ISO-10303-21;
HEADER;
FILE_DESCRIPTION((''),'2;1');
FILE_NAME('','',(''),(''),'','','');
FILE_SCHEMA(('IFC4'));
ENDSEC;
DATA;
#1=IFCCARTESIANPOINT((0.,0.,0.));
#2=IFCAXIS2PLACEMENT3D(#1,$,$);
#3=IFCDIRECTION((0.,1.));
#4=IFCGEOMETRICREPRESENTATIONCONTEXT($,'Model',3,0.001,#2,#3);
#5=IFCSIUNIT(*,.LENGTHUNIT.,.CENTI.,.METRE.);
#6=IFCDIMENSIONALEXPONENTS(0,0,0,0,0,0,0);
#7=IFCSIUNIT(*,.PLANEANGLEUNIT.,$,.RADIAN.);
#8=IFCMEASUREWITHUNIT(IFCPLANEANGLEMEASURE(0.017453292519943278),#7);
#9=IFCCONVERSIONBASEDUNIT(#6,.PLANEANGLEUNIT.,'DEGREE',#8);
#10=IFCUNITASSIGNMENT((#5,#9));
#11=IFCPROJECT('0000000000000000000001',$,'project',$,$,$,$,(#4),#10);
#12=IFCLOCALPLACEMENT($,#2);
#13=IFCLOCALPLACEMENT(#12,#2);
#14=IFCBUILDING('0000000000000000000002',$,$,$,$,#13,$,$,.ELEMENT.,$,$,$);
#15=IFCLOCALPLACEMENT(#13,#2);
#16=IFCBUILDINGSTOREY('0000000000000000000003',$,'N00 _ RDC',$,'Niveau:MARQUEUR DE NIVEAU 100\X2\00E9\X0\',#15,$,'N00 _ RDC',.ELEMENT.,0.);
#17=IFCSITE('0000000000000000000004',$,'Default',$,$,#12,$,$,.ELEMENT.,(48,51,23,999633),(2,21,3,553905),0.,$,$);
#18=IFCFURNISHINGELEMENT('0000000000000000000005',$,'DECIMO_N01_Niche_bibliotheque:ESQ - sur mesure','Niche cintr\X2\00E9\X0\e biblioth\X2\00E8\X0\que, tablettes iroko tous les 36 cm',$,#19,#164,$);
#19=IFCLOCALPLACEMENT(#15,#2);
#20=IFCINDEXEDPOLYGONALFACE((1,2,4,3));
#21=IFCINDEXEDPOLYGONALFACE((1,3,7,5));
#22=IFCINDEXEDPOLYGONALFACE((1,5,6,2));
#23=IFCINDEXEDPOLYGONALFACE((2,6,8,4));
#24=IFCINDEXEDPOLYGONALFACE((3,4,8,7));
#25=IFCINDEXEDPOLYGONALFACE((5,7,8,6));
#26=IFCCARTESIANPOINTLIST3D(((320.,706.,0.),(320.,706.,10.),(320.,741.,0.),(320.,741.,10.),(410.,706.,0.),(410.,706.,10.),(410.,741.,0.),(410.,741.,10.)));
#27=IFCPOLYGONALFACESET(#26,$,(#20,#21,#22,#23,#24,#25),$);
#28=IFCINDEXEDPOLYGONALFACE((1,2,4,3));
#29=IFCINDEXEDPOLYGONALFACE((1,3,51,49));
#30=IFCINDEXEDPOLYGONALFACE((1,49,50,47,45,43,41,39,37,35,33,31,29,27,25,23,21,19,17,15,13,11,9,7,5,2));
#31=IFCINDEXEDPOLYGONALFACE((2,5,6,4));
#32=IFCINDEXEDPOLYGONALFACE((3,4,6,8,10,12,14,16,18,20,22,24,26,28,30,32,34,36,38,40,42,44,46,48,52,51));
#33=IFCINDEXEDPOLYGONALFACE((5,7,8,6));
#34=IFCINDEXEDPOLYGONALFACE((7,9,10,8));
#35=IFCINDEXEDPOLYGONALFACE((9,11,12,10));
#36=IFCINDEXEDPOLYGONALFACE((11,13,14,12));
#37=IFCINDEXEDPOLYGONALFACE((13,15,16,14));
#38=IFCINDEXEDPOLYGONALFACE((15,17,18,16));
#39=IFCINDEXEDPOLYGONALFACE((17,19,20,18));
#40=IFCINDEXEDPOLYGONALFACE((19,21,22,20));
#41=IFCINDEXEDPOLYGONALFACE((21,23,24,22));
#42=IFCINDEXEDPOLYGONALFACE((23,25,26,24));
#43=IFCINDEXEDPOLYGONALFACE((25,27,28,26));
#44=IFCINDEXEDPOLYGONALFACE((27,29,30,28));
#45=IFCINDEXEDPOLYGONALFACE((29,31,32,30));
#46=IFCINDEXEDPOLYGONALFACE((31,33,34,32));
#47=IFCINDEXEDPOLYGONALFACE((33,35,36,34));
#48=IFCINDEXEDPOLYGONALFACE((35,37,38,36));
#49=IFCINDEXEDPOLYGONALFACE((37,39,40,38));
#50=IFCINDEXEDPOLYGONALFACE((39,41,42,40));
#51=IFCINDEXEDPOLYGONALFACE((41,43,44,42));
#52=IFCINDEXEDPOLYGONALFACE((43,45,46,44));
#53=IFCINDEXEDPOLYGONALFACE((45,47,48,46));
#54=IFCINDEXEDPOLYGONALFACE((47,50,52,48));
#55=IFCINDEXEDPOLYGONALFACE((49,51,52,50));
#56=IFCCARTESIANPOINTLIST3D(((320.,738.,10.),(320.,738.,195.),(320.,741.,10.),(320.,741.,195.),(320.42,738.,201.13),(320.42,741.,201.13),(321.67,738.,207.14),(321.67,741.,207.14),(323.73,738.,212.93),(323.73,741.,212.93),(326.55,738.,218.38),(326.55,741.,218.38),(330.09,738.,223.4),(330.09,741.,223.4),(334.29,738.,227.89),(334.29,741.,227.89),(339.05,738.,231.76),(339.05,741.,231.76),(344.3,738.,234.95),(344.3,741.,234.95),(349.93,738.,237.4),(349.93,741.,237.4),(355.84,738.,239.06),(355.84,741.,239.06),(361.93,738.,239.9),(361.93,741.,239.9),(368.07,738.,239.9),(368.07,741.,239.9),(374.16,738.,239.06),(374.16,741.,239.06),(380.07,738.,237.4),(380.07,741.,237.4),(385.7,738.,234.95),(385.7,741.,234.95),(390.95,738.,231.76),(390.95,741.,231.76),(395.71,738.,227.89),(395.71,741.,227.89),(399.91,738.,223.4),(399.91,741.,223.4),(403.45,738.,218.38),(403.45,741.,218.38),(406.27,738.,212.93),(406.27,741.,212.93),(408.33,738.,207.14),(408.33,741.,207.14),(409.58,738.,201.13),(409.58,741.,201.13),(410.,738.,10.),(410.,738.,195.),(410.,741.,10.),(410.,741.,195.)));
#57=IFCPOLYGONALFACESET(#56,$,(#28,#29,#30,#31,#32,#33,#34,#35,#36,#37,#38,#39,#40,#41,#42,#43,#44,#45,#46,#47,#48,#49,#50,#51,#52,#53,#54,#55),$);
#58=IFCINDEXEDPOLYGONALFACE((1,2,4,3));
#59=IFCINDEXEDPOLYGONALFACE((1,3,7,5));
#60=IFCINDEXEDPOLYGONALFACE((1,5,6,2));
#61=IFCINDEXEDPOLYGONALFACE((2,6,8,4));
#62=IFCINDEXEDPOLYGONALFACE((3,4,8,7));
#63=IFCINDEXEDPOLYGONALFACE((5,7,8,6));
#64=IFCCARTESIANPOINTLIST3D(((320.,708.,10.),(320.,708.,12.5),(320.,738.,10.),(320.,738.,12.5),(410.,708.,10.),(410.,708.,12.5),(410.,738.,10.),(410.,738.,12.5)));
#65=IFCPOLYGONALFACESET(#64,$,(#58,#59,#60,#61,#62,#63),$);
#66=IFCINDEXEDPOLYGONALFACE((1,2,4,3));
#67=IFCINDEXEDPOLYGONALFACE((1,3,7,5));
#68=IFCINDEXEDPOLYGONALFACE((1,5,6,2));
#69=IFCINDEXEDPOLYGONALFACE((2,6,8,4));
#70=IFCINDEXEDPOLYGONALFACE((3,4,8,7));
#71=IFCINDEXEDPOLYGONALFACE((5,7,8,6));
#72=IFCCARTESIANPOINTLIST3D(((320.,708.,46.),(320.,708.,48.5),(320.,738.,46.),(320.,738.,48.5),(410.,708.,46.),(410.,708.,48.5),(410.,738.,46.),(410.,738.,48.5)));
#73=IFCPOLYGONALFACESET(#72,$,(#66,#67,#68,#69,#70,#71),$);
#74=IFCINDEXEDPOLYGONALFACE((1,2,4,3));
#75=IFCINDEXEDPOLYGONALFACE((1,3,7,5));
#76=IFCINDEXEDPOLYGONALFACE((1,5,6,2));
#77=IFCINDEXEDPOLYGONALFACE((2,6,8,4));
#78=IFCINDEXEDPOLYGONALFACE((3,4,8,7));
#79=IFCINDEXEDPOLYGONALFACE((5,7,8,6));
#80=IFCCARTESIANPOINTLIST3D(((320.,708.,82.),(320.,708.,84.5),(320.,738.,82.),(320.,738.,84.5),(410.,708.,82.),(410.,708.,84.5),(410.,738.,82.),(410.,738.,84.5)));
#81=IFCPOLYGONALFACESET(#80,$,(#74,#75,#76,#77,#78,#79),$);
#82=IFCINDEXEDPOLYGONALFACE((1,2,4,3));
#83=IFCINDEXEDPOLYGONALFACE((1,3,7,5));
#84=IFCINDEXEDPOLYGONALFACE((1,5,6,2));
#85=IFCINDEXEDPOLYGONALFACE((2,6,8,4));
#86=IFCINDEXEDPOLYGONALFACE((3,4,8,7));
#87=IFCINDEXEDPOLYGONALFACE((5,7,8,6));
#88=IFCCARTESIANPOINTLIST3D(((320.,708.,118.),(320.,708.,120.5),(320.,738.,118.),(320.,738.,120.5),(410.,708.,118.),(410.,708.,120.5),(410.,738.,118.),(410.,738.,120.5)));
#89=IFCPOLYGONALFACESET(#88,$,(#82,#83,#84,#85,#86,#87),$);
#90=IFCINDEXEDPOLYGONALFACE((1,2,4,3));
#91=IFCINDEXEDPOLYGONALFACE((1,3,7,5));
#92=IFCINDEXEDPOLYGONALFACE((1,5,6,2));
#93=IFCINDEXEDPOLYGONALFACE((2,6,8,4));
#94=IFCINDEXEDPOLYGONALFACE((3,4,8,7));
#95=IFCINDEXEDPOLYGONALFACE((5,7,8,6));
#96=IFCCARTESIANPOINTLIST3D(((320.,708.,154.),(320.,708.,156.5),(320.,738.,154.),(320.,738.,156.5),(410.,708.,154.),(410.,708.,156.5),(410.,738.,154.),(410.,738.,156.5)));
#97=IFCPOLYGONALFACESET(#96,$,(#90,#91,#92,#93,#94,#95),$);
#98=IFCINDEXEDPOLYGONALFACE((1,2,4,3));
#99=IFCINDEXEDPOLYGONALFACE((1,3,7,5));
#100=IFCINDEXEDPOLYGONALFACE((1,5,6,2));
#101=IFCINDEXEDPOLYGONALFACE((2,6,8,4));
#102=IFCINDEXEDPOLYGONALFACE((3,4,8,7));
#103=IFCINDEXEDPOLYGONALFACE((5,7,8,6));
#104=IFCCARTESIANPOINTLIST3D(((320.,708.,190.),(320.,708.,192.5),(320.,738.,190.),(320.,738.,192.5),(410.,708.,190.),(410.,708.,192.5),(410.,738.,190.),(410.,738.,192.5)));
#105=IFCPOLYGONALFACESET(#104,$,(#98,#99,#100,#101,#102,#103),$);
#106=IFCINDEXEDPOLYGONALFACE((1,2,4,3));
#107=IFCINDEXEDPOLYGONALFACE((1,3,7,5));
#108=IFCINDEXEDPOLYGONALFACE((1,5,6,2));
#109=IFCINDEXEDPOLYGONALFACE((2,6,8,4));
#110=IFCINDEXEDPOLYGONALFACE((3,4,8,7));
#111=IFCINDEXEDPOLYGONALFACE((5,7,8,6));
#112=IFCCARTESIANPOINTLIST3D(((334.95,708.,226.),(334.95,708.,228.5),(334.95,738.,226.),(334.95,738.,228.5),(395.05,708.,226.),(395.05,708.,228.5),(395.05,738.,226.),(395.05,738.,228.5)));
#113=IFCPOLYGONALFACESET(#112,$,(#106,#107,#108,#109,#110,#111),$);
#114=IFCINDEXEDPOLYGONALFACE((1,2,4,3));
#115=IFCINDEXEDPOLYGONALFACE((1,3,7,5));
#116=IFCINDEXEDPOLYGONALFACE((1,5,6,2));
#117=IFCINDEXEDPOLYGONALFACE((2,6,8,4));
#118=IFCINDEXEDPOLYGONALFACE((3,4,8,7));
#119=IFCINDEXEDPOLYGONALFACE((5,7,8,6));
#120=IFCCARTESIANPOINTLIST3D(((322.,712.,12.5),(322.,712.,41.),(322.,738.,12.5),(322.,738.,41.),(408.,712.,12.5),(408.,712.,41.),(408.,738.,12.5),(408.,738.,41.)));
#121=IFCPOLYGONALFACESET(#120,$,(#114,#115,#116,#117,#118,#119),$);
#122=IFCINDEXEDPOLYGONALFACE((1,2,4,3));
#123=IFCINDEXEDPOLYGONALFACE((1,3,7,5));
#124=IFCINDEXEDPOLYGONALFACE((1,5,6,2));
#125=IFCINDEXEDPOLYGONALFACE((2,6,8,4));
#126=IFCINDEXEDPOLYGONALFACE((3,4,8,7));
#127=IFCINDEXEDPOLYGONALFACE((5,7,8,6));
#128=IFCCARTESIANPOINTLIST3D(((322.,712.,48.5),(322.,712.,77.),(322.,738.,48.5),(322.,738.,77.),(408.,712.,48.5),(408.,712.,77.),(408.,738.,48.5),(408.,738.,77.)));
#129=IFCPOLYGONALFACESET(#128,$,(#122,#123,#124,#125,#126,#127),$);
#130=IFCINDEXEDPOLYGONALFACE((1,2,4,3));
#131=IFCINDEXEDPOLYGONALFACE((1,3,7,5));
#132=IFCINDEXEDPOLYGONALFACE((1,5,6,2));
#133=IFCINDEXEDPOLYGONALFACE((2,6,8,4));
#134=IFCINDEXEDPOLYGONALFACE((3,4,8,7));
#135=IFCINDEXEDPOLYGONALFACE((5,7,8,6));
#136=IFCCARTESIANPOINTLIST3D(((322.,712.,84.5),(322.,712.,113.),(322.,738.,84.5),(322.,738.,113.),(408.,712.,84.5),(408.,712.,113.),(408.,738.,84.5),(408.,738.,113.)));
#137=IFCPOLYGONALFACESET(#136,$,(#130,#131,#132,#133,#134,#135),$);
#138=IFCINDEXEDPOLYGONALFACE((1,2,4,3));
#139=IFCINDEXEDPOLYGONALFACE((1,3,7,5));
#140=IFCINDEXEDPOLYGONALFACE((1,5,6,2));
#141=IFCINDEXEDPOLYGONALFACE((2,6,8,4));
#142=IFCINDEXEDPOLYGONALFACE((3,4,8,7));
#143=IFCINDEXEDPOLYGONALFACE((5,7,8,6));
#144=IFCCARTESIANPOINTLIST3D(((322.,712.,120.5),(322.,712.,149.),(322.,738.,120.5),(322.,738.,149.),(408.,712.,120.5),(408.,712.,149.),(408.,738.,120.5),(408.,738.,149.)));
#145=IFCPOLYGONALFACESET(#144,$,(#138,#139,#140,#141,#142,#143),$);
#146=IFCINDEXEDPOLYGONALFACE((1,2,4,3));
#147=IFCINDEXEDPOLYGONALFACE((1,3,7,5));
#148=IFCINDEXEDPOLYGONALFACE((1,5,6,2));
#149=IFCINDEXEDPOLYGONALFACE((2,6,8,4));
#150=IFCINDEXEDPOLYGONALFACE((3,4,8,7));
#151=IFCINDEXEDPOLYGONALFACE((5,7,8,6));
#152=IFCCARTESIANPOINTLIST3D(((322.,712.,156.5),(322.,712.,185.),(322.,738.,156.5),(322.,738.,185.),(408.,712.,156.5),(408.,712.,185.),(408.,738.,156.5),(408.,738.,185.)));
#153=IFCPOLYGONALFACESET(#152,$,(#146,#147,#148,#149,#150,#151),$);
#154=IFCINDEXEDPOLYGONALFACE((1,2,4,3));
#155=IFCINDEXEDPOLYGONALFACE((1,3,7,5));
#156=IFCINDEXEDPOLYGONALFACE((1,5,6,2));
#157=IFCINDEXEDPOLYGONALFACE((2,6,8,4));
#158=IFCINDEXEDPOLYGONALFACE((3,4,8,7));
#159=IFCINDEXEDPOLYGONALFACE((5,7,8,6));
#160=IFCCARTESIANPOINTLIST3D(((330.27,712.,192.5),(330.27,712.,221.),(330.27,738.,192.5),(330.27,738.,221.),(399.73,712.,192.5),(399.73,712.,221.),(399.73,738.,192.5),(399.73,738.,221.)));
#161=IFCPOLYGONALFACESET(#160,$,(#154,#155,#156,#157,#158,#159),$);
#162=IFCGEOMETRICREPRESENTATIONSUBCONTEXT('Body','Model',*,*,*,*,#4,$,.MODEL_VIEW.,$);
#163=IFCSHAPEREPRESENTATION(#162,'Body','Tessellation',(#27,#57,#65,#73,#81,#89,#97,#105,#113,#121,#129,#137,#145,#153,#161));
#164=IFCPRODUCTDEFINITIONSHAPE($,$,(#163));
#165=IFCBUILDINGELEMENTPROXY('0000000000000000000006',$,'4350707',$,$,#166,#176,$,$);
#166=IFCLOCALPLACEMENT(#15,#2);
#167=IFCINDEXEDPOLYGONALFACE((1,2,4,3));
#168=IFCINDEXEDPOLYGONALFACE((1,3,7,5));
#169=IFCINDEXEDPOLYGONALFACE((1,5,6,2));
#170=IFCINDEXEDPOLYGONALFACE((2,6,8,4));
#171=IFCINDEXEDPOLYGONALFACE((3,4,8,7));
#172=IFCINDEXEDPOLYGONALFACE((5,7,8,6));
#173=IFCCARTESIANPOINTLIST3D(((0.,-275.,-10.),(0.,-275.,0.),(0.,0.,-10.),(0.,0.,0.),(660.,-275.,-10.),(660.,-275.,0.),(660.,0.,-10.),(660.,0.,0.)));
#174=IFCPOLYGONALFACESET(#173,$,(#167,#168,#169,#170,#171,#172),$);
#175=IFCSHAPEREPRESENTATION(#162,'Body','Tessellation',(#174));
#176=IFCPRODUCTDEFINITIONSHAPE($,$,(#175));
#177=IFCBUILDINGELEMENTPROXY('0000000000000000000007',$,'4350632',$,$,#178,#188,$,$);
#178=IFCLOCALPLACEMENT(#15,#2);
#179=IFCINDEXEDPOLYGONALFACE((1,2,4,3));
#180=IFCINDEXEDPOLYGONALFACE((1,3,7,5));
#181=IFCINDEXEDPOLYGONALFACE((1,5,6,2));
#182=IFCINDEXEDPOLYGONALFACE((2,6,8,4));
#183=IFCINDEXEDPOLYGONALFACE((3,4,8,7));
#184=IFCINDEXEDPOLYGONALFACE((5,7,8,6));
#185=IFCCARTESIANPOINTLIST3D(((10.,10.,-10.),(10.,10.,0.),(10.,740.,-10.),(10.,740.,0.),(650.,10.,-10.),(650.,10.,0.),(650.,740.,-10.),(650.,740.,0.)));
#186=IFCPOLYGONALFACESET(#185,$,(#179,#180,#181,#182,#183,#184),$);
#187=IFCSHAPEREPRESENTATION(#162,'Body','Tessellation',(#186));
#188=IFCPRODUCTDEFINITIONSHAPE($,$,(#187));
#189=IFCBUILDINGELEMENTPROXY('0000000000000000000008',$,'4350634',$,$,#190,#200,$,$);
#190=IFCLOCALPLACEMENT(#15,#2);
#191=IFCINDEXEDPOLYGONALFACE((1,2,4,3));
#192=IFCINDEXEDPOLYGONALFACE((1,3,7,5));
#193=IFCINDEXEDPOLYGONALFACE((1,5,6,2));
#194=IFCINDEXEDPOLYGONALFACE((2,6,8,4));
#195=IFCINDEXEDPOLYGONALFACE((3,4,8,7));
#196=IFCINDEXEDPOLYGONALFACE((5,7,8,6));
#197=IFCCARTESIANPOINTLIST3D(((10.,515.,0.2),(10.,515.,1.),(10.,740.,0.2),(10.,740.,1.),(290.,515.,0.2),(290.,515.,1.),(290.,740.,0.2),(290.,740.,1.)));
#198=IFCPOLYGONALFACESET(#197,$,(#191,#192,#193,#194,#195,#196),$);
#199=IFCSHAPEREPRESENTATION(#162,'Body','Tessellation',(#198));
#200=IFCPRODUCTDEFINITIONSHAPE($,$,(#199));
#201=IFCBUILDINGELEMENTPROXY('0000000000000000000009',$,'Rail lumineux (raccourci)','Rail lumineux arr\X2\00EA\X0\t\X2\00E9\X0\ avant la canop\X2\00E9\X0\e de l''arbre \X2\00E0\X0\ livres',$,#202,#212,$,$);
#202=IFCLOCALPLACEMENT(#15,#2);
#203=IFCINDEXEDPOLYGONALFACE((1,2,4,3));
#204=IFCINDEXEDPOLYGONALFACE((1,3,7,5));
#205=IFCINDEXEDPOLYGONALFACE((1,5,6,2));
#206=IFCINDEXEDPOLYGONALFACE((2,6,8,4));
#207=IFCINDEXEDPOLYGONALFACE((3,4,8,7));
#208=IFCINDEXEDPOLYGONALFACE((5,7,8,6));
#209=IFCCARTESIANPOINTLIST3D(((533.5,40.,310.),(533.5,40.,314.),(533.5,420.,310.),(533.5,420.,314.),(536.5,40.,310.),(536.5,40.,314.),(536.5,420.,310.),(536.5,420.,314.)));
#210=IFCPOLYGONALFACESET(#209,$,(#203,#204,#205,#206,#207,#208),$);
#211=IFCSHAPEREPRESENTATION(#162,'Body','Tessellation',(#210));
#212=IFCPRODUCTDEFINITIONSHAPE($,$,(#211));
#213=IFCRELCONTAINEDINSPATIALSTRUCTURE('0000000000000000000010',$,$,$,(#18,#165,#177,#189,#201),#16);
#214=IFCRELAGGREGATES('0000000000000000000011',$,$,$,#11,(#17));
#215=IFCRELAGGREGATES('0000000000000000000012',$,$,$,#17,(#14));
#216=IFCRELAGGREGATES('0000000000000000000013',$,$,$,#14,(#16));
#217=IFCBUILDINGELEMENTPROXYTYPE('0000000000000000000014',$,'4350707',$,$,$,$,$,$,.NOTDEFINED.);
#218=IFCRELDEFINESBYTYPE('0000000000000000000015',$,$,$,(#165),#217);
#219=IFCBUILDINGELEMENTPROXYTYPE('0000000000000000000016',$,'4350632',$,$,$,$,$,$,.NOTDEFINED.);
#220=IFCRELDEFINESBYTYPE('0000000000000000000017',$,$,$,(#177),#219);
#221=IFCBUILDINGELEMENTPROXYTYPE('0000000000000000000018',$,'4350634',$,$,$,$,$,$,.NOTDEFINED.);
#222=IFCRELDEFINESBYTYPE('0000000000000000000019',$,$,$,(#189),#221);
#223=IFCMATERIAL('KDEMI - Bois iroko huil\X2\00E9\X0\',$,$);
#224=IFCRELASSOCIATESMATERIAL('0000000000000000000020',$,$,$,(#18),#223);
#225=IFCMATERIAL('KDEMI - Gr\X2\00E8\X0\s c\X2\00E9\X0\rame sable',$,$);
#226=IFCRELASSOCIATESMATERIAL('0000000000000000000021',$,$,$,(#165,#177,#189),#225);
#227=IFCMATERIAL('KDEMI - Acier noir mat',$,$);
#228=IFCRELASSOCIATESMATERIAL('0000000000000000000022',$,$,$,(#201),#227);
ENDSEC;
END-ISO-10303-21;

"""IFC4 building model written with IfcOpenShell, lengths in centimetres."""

from ifc_helpers import new_model, entity, si_unit, converted_unit, direction, frame, frame_2d, origin, origin_with_axes, origin_2d_with_axis, place, context, subcontext, project, spatial, polyline, rectangle, outline, extrude, material, type_object, element, save


model = new_model("IFC4")

# Units and contexts
model_context = context("Model", 3, precision=0.001, world=origin(), true_north=direction((0.0, 1.0)))
body_context = subcontext(model_context, "Body", "Model", "MODEL_VIEW")
ifc_project = project(units=[si_unit("LENGTHUNIT", "METRE", prefix="CENTI"), converted_unit("PLANEANGLEUNIT", "DEGREE", entity("IfcPlaneAngleMeasure", 0.017453292519943278), si_unit("PLANEANGLEUNIT", "RADIAN"), dimensions=[0, 0, 0, 0, 0, 0, 0])], contexts=[model_context])

# Site, building, storey
site_placement = place(None, origin())
site = spatial("IfcSite", under=ifc_project, at=site_placement, Name="Default", CompositionType="ELEMENT", RefLatitude=(48, 51, 23, 999633), RefLongitude=(2, 21, 3, 553905), RefElevation=0.0)
building_placement = place(site_placement, origin())
building = spatial("IfcBuilding", under=site, at=building_placement, CompositionType="ELEMENT")
storey_placement = place(building_placement, origin())
storey = spatial("IfcBuildingStorey", under=building, at=storey_placement, Name="N00 _ RDC", ObjectType="Niveau:MARQUEUR DE NIVEAU 100é", LongName="N00 _ RDC", CompositionType="ELEMENT", Elevation=0.0)

# Shared definitions
ifc_material_1 = material(Name="KDEMI - Acier noir mat")

# Furnishing element
ifc_material_2 = material(Name="KDEMI - Bois iroko huilé")
furnishing_1_placement = place(storey_placement, origin_with_axes())
element("IfcFurnishingElement", 1, at=furnishing_1_placement, inside=storey, material=ifc_material_2, Name="DECIMO_N01_Niche_bibliotheque:ESQ - sur mesure", Description="Niche cintrée bibliothèque, tablettes iroko tous les 36 cm", context=body_context, shape_type="SweptSolid", body=[
    extrude(rectangle(XDim=90.0, YDim=35.0, at=frame_2d((365.0, 723.5))), origin(), (0.0, 0.0, 1.0), 10.0),
    extrude(outline(polyline([(320.0, 10.0), (410.0, 10.0), (410.0, 195.0), (409.58, 201.13), (408.33, 207.14), (406.27, 212.93), (403.45, 218.38), (399.91, 223.4), (395.71, 227.89), (390.95, 231.76), (385.7, 234.95), (380.07, 237.4), (374.16, 239.06), (368.07, 239.9), (361.93, 239.9), (355.84, 239.06), (349.93, 237.4), (344.3, 234.95), (339.05, 231.76), (334.29, 227.89), (330.09, 223.4), (326.55, 218.38), (323.73, 212.93), (321.67, 207.14), (320.42, 201.13), (320.0, 195.0), (320.0, 10.0)])), frame((0.0, 741.0, 0.0), z_axis=(0.0, -1.0, 0.0), x_axis=(1.0, 0.0, 0.0)), (0.0, 0.0, 1.0), 3.0),
    extrude(rectangle(XDim=90.0, YDim=30.0, at=frame_2d((365.0, 723.0))), frame((0.0, 0.0, 10.0)), (0.0, 0.0, 1.0), 2.5),
    extrude(rectangle(XDim=90.0, YDim=30.0, at=frame_2d((365.0, 723.0))), frame((0.0, 0.0, 46.0)), (0.0, 0.0, 1.0), 2.5),
    extrude(rectangle(XDim=90.0, YDim=30.0, at=frame_2d((365.0, 723.0))), frame((0.0, 0.0, 82.0)), (0.0, 0.0, 1.0), 2.5),
    extrude(rectangle(XDim=90.0, YDim=30.0, at=frame_2d((365.0, 723.0))), frame((0.0, 0.0, 118.0)), (0.0, 0.0, 1.0), 2.5),
    extrude(rectangle(XDim=90.0, YDim=30.0, at=frame_2d((365.0, 723.0))), frame((0.0, 0.0, 154.0)), (0.0, 0.0, 1.0), 2.5),
    extrude(rectangle(XDim=90.0, YDim=30.0, at=frame_2d((365.0, 723.0))), frame((0.0, 0.0, 190.0)), (0.0, 0.0, 1.0), 2.5),
    extrude(rectangle(XDim=60.09, YDim=30.0, at=frame_2d((365.0, 723.0))), frame((0.0, 0.0, 226.0)), (0.0, 0.0, 1.0), 2.5),
    extrude(rectangle(XDim=86.0, YDim=26.0, at=frame_2d((365.0, 725.0))), frame((0.0, 0.0, 12.5)), (0.0, 0.0, 1.0), 28.5),
    extrude(rectangle(XDim=86.0, YDim=26.0, at=frame_2d((365.0, 725.0))), frame((0.0, 0.0, 48.5)), (0.0, 0.0, 1.0), 28.5),
    extrude(rectangle(XDim=86.0, YDim=26.0, at=frame_2d((365.0, 725.0))), frame((0.0, 0.0, 84.5)), (0.0, 0.0, 1.0), 28.5),
    extrude(rectangle(XDim=86.0, YDim=26.0, at=frame_2d((365.0, 725.0))), frame((0.0, 0.0, 120.5)), (0.0, 0.0, 1.0), 28.5),
    extrude(rectangle(XDim=86.0, YDim=26.0, at=frame_2d((365.0, 725.0))), frame((0.0, 0.0, 156.5)), (0.0, 0.0, 1.0), 28.5),
    extrude(rectangle(XDim=69.46, YDim=26.0, at=frame_2d((365.0, 725.0))), frame((0.0, 0.0, 192.5)), (0.0, 0.0, 1.0), 28.5),
])

# Building element proxies
ifc_material_3 = material(Name="KDEMI - Grès cérame sable")
building_element_proxy_type_1 = type_object("IfcBuildingElementProxyType", Name="4350707", PredefinedType="NOTDEFINED")
proxy_1_placement = place(storey_placement, origin())
element("IfcBuildingElementProxy", 2, at=proxy_1_placement, inside=storey, type_object=building_element_proxy_type_1, material=ifc_material_3, Name="4350707", context=body_context, shape_type="SweptSolid", body=[
    extrude(rectangle(XDim=660.0, YDim=275.0, at=origin_2d_with_axis()), frame((330.0, -137.5, -10.0)), (0.0, 0.0, 1.0), 10.0),
])
building_element_proxy_type_2 = type_object("IfcBuildingElementProxyType", Name="4350632", PredefinedType="NOTDEFINED")
proxy_2_placement = place(storey_placement, origin())
element("IfcBuildingElementProxy", 3, at=proxy_2_placement, inside=storey, type_object=building_element_proxy_type_2, material=ifc_material_3, Name="4350632", context=body_context, shape_type="SweptSolid", body=[
    extrude(rectangle(XDim=640.0, YDim=730.0, at=origin_2d_with_axis()), frame((330.0, 375.0, -10.0)), (0.0, 0.0, 1.0), 10.0),
])
building_element_proxy_type_3 = type_object("IfcBuildingElementProxyType", Name="4350634", PredefinedType="NOTDEFINED")
proxy_3_placement = place(storey_placement, origin())
element("IfcBuildingElementProxy", 4, at=proxy_3_placement, inside=storey, type_object=building_element_proxy_type_3, material=ifc_material_3, Name="4350634", context=body_context, shape_type="SweptSolid", body=[
    extrude(rectangle(XDim=280.0, YDim=225.0, at=frame_2d((0.0, 0.0), x_axis=(1.0, 0.0))), frame((150.0, 627.5, 0.2)), (0.0, 0.0, 1.0), 0.8),
])
proxy_4_placement = place(storey_placement, origin_with_axes())
element("IfcBuildingElementProxy", 5, at=proxy_4_placement, inside=storey, material=ifc_material_1, Name="Rail lumineux (raccourci)", Description="Rail lumineux arrêté avant la canopée de l'arbre à livres", context=body_context, shape_type="SweptSolid", body=[
    extrude(rectangle(XDim=3.0, YDim=380.0, at=frame_2d((535.0, 230.0))), frame((0.0, 0.0, 310.0)), (0.0, 0.0, 1.0), 4.0),
])

save(model, "model.ifc")
